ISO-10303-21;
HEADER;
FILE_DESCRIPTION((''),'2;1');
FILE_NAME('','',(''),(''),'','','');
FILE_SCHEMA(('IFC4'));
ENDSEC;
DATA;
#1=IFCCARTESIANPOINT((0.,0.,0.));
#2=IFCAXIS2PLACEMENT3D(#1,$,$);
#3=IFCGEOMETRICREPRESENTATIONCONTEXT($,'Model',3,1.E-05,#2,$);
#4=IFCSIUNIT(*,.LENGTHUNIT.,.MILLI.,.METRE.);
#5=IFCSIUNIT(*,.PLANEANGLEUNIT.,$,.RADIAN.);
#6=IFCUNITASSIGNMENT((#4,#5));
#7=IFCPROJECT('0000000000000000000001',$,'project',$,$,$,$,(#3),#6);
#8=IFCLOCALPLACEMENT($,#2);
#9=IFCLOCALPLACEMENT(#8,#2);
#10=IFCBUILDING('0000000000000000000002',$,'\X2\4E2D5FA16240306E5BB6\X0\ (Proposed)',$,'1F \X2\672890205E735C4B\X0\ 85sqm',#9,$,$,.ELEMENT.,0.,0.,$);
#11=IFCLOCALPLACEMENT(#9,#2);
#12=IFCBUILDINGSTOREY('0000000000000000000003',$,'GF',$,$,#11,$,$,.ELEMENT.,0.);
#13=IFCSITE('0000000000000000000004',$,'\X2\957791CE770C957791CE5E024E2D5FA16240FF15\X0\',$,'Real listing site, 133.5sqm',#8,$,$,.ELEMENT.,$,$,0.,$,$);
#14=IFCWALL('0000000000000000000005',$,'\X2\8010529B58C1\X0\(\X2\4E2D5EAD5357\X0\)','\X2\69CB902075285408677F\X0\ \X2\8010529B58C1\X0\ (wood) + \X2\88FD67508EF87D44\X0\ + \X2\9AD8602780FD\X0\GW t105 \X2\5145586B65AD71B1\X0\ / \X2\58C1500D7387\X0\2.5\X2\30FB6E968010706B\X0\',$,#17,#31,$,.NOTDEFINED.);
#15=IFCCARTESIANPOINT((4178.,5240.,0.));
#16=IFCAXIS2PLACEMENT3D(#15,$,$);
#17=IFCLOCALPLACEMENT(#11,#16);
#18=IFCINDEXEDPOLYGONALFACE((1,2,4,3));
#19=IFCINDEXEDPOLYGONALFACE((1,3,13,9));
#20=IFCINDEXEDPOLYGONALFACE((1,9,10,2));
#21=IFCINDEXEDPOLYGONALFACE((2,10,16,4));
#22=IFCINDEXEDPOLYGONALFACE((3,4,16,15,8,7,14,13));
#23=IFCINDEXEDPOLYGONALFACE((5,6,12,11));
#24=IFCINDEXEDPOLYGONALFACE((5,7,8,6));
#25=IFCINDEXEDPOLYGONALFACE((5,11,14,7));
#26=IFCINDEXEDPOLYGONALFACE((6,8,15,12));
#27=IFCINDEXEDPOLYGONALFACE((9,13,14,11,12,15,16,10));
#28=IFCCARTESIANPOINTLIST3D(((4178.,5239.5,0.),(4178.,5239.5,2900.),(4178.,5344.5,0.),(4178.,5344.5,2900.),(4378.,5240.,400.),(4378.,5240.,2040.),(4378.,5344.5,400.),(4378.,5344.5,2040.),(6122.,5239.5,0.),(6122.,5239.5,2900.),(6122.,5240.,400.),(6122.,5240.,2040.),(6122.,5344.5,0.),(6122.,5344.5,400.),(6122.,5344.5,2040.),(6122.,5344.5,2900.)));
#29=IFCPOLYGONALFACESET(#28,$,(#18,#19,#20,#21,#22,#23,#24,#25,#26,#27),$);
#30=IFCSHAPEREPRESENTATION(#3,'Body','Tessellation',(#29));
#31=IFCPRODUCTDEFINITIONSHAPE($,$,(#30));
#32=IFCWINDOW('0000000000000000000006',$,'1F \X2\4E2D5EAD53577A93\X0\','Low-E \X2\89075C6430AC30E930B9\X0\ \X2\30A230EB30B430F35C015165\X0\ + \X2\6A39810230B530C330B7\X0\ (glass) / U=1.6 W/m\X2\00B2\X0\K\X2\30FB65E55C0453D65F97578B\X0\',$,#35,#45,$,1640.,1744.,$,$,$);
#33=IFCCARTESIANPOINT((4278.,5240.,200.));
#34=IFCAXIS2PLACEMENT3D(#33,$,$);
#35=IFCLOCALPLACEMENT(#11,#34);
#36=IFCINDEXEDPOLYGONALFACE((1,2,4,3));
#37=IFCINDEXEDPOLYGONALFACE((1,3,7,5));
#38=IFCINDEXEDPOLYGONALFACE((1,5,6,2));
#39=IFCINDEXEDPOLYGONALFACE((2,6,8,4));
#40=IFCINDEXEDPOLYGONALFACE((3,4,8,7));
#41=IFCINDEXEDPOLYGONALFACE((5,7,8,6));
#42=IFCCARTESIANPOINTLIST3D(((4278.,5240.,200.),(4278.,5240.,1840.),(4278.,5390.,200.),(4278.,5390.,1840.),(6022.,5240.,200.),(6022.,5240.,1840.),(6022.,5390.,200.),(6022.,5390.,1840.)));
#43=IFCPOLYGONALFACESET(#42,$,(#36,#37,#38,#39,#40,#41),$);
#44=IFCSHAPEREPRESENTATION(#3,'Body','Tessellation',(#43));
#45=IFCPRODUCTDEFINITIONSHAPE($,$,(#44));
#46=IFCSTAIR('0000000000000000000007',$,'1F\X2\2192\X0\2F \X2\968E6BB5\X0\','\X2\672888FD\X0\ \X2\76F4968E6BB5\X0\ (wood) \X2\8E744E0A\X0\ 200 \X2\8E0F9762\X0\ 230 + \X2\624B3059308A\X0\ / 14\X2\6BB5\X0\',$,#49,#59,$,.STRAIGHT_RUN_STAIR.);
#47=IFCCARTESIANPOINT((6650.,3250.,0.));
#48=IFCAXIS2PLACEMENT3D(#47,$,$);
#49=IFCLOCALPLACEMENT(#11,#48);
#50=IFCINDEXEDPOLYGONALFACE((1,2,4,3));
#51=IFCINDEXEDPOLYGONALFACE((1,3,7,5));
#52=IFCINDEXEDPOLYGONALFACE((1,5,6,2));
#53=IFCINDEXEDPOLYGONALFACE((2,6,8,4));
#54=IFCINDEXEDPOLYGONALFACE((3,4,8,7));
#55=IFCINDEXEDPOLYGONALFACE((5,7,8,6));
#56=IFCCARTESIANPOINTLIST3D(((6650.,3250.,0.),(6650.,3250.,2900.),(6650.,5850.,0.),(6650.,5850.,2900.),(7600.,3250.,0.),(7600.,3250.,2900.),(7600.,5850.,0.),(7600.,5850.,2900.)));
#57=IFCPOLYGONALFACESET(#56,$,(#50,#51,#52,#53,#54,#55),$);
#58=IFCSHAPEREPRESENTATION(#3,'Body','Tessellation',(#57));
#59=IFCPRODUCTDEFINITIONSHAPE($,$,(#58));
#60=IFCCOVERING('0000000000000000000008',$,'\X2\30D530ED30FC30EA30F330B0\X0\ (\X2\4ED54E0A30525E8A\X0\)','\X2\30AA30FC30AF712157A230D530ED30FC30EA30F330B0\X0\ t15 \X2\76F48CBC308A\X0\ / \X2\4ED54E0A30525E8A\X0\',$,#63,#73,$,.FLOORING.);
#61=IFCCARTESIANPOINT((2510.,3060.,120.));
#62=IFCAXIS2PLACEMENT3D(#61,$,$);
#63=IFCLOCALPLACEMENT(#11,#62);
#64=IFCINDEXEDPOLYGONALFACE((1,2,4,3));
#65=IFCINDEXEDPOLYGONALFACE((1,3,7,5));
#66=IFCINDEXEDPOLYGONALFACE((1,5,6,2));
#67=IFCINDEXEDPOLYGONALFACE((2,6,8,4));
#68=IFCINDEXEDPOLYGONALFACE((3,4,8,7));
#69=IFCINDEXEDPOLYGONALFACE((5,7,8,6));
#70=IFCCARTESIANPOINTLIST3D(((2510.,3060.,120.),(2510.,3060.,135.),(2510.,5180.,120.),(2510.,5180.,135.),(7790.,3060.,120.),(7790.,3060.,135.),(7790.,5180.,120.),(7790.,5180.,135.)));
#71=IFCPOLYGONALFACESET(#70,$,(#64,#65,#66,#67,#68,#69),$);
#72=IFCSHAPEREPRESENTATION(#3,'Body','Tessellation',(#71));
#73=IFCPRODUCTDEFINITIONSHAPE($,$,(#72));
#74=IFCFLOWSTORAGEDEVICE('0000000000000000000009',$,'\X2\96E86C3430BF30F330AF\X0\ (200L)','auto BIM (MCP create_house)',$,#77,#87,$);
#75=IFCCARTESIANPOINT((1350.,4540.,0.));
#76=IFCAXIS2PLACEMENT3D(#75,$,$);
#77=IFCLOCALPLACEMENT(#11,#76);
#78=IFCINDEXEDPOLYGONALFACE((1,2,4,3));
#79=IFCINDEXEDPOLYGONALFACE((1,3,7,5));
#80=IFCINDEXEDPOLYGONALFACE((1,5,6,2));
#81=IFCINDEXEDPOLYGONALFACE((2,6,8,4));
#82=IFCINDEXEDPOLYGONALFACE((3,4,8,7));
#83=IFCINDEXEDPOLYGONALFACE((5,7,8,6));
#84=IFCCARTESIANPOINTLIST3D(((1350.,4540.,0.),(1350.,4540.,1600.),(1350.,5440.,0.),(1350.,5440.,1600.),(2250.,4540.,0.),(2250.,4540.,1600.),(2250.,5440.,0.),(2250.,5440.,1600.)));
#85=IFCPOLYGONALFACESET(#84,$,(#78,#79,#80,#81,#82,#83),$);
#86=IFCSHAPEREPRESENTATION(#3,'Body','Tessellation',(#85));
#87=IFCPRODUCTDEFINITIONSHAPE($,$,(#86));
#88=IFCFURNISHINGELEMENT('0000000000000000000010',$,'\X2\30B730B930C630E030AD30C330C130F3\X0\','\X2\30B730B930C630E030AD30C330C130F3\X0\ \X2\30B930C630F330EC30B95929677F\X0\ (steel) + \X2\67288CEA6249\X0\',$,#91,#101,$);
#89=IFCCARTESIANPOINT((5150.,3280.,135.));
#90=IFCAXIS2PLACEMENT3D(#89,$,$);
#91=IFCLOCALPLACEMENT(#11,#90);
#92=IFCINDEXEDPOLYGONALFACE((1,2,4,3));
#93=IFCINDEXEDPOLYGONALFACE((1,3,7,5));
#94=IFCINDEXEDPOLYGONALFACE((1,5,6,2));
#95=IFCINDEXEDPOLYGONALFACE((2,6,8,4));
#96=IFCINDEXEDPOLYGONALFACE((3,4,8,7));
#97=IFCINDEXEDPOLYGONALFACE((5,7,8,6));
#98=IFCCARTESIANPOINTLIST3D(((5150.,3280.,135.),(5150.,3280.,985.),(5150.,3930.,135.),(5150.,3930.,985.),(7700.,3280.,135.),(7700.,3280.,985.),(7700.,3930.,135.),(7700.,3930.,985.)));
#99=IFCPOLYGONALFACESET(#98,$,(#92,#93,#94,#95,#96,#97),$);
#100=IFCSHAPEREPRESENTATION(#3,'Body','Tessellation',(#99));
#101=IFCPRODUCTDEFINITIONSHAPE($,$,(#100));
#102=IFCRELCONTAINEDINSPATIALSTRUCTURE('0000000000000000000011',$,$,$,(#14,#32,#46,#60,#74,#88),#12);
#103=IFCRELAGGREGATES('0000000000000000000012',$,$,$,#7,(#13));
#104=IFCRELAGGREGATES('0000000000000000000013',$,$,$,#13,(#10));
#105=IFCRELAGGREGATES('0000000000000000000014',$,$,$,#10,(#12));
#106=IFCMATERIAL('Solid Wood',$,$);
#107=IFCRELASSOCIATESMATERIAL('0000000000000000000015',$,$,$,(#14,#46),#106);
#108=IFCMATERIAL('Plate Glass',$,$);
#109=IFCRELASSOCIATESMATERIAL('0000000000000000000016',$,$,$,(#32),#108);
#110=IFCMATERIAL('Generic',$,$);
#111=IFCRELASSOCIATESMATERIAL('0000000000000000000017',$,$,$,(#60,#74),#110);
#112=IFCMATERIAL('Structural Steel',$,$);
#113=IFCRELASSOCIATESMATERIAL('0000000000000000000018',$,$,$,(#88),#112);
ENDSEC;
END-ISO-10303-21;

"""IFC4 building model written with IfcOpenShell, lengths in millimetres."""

from ifc_helpers import new_model, si_unit, frame, frame_2d, origin, place, context, project, spatial, rectangle, extrude, material, element, fill, save


model = new_model("IFC4")

# Units and contexts
model_context = context("Model", 3, precision=1e-05, world=origin())
ifc_project = project(units=[si_unit("LENGTHUNIT", "METRE", prefix="MILLI"), si_unit("PLANEANGLEUNIT", "RADIAN")], contexts=[model_context])

# Site, building, storey
site_placement = place(None, origin())
site = spatial("IfcSite", under=ifc_project, at=site_placement, Name="長野県長野市中御所５", ObjectType="Real listing site, 133.5sqm", CompositionType="ELEMENT", RefElevation=0.0)
building_placement = place(site_placement, origin())
building = spatial("IfcBuilding", under=site, at=building_placement, Name="中御所の家 (Proposed)", ObjectType="1F 木造平屋 85sqm", CompositionType="ELEMENT", ElevationOfRefHeight=0.0, ElevationOfTerrain=0.0)
storey_placement = place(building_placement, origin())
storey = spatial("IfcBuildingStorey", under=building, at=storey_placement, Name="GF", CompositionType="ELEMENT", Elevation=0.0)

# Shared definitions
ifc_material_1 = material(Name="Solid Wood")
ifc_material_2 = material(Name="Generic")

# Shared definitions
ifc_material_3 = material(Name="Plate Glass")

# Wall, opening, window
wall_1_placement = place(storey_placement, frame((4178.0, 5240.0, 0.0)))
wall_1 = element("IfcWall", 1, at=wall_1_placement, inside=storey, material=ifc_material_1, Name="耐力壁(中庭南)", Description="構造用合板 耐力壁 (wood) + 製材軸組 + 高性能GW t105 充填断熱 / 壁倍率2.5・準耐火", PredefinedType="NOTDEFINED", context=model_context, shape_type="SweptSolid", body=[
    extrude(rectangle(XDim=1944.0, YDim=105.0, at=frame_2d((972.0, 52.0))), frame((4178.0, 5240.0, 0.0)), (0.0, 0.0, 1.0), 2900.0),
])
opening_1_placement = place(storey_placement, frame((4278.0, 5240.0, 200.0)))
opening_1 = element("IfcOpeningElement", 2, at=opening_1_placement, cuts=wall_1, PredefinedType="NOTDEFINED", context=model_context, shape_type="SweptSolid", body=[
    extrude(rectangle(XDim=1744.0, YDim=150.0, at=frame_2d((872.0, 75.0))), frame((4278.0, 5240.0, 200.0)), (0.0, 0.0, 1.0), 1640.0),
])
window_1_placement = place(storey_placement, frame((4278.0, 5240.0, 200.0)))
window_1 = element("IfcWindow", 3, at=window_1_placement, inside=storey, material=ifc_material_3, Name="1F 中庭南窓", Description="Low-E 複層ガラス アルゴン封入 + 樹脂サッシ (glass) / U=1.6 W/m²K・日射取得型", OverallHeight=1640.0, OverallWidth=1744.0, context=model_context, shape_type="SweptSolid", body=[
    extrude(rectangle(XDim=1744.0, YDim=150.0, at=frame_2d((872.0, 75.0))), frame((4278.0, 5240.0, 200.0)), (0.0, 0.0, 1.0), 1640.0),
])
fill(opening_1, window_1)

# Stair
stair_placement = place(storey_placement, frame((6650.0, 3250.0, 0.0)))
element("IfcStair", 4, at=stair_placement, inside=storey, material=ifc_material_1, Name="1F→2F 階段", Description="木製 直階段 (wood) 蹴上 200 踏面 230 + 手すり / 14段", PredefinedType="STRAIGHT_RUN_STAIR", context=model_context, shape_type="SweptSolid", body=[
    extrude(rectangle(XDim=950.0, YDim=2600.0, at=frame_2d((475.0, 1300.0))), frame((6650.0, 3250.0, 0.0)), (0.0, 0.0, 1.0), 2900.0),
])

# Covering
covering_placement = place(storey_placement, frame((2510.0, 3060.0, 120.0)))
element("IfcCovering", 5, at=covering_placement, inside=storey, material=ifc_material_2, Name="フローリング (仕上げ床)", Description="オーク無垢フローリング t15 直貼り / 仕上げ床", PredefinedType="FLOORING", context=model_context, shape_type="SweptSolid", body=[
    extrude(rectangle(XDim=5280.0, YDim=2120.0, at=frame_2d((2640.0, 1060.0))), frame((2510.0, 3060.0, 120.0)), (0.0, 0.0, 1.0), 15.0),
])

# Flow storage device
flow_storage_device_placement = place(storey_placement, frame((1350.0, 4540.0, 0.0)))
element("IfcFlowStorageDevice", 6, at=flow_storage_device_placement, inside=storey, material=ifc_material_2, Name="雨水タンク (200L)", Description="auto BIM (MCP create_house)", context=model_context, shape_type="SweptSolid", body=[
    extrude(rectangle(XDim=900.0, YDim=900.0, at=frame_2d((450.0, 450.0))), frame((1350.0, 4540.0, 0.0)), (0.0, 0.0, 1.0), 1600.0),
])

# Furnishing element
ifc_material_4 = material(Name="Structural Steel")
furnishing_placement = place(storey_placement, frame((5150.0, 3280.0, 135.0)))
element("IfcFurnishingElement", 7, at=furnishing_placement, inside=storey, material=ifc_material_4, Name="システムキッチン", Description="システムキッチン ステンレス天板 (steel) + 木質扉", context=model_context, shape_type="SweptSolid", body=[
    extrude(rectangle(XDim=2550.0, YDim=650.0, at=frame_2d((1275.0, 325.0))), frame((5150.0, 3280.0, 135.0)), (0.0, 0.0, 1.0), 850.0),
])

save(model, "model.ifc")
